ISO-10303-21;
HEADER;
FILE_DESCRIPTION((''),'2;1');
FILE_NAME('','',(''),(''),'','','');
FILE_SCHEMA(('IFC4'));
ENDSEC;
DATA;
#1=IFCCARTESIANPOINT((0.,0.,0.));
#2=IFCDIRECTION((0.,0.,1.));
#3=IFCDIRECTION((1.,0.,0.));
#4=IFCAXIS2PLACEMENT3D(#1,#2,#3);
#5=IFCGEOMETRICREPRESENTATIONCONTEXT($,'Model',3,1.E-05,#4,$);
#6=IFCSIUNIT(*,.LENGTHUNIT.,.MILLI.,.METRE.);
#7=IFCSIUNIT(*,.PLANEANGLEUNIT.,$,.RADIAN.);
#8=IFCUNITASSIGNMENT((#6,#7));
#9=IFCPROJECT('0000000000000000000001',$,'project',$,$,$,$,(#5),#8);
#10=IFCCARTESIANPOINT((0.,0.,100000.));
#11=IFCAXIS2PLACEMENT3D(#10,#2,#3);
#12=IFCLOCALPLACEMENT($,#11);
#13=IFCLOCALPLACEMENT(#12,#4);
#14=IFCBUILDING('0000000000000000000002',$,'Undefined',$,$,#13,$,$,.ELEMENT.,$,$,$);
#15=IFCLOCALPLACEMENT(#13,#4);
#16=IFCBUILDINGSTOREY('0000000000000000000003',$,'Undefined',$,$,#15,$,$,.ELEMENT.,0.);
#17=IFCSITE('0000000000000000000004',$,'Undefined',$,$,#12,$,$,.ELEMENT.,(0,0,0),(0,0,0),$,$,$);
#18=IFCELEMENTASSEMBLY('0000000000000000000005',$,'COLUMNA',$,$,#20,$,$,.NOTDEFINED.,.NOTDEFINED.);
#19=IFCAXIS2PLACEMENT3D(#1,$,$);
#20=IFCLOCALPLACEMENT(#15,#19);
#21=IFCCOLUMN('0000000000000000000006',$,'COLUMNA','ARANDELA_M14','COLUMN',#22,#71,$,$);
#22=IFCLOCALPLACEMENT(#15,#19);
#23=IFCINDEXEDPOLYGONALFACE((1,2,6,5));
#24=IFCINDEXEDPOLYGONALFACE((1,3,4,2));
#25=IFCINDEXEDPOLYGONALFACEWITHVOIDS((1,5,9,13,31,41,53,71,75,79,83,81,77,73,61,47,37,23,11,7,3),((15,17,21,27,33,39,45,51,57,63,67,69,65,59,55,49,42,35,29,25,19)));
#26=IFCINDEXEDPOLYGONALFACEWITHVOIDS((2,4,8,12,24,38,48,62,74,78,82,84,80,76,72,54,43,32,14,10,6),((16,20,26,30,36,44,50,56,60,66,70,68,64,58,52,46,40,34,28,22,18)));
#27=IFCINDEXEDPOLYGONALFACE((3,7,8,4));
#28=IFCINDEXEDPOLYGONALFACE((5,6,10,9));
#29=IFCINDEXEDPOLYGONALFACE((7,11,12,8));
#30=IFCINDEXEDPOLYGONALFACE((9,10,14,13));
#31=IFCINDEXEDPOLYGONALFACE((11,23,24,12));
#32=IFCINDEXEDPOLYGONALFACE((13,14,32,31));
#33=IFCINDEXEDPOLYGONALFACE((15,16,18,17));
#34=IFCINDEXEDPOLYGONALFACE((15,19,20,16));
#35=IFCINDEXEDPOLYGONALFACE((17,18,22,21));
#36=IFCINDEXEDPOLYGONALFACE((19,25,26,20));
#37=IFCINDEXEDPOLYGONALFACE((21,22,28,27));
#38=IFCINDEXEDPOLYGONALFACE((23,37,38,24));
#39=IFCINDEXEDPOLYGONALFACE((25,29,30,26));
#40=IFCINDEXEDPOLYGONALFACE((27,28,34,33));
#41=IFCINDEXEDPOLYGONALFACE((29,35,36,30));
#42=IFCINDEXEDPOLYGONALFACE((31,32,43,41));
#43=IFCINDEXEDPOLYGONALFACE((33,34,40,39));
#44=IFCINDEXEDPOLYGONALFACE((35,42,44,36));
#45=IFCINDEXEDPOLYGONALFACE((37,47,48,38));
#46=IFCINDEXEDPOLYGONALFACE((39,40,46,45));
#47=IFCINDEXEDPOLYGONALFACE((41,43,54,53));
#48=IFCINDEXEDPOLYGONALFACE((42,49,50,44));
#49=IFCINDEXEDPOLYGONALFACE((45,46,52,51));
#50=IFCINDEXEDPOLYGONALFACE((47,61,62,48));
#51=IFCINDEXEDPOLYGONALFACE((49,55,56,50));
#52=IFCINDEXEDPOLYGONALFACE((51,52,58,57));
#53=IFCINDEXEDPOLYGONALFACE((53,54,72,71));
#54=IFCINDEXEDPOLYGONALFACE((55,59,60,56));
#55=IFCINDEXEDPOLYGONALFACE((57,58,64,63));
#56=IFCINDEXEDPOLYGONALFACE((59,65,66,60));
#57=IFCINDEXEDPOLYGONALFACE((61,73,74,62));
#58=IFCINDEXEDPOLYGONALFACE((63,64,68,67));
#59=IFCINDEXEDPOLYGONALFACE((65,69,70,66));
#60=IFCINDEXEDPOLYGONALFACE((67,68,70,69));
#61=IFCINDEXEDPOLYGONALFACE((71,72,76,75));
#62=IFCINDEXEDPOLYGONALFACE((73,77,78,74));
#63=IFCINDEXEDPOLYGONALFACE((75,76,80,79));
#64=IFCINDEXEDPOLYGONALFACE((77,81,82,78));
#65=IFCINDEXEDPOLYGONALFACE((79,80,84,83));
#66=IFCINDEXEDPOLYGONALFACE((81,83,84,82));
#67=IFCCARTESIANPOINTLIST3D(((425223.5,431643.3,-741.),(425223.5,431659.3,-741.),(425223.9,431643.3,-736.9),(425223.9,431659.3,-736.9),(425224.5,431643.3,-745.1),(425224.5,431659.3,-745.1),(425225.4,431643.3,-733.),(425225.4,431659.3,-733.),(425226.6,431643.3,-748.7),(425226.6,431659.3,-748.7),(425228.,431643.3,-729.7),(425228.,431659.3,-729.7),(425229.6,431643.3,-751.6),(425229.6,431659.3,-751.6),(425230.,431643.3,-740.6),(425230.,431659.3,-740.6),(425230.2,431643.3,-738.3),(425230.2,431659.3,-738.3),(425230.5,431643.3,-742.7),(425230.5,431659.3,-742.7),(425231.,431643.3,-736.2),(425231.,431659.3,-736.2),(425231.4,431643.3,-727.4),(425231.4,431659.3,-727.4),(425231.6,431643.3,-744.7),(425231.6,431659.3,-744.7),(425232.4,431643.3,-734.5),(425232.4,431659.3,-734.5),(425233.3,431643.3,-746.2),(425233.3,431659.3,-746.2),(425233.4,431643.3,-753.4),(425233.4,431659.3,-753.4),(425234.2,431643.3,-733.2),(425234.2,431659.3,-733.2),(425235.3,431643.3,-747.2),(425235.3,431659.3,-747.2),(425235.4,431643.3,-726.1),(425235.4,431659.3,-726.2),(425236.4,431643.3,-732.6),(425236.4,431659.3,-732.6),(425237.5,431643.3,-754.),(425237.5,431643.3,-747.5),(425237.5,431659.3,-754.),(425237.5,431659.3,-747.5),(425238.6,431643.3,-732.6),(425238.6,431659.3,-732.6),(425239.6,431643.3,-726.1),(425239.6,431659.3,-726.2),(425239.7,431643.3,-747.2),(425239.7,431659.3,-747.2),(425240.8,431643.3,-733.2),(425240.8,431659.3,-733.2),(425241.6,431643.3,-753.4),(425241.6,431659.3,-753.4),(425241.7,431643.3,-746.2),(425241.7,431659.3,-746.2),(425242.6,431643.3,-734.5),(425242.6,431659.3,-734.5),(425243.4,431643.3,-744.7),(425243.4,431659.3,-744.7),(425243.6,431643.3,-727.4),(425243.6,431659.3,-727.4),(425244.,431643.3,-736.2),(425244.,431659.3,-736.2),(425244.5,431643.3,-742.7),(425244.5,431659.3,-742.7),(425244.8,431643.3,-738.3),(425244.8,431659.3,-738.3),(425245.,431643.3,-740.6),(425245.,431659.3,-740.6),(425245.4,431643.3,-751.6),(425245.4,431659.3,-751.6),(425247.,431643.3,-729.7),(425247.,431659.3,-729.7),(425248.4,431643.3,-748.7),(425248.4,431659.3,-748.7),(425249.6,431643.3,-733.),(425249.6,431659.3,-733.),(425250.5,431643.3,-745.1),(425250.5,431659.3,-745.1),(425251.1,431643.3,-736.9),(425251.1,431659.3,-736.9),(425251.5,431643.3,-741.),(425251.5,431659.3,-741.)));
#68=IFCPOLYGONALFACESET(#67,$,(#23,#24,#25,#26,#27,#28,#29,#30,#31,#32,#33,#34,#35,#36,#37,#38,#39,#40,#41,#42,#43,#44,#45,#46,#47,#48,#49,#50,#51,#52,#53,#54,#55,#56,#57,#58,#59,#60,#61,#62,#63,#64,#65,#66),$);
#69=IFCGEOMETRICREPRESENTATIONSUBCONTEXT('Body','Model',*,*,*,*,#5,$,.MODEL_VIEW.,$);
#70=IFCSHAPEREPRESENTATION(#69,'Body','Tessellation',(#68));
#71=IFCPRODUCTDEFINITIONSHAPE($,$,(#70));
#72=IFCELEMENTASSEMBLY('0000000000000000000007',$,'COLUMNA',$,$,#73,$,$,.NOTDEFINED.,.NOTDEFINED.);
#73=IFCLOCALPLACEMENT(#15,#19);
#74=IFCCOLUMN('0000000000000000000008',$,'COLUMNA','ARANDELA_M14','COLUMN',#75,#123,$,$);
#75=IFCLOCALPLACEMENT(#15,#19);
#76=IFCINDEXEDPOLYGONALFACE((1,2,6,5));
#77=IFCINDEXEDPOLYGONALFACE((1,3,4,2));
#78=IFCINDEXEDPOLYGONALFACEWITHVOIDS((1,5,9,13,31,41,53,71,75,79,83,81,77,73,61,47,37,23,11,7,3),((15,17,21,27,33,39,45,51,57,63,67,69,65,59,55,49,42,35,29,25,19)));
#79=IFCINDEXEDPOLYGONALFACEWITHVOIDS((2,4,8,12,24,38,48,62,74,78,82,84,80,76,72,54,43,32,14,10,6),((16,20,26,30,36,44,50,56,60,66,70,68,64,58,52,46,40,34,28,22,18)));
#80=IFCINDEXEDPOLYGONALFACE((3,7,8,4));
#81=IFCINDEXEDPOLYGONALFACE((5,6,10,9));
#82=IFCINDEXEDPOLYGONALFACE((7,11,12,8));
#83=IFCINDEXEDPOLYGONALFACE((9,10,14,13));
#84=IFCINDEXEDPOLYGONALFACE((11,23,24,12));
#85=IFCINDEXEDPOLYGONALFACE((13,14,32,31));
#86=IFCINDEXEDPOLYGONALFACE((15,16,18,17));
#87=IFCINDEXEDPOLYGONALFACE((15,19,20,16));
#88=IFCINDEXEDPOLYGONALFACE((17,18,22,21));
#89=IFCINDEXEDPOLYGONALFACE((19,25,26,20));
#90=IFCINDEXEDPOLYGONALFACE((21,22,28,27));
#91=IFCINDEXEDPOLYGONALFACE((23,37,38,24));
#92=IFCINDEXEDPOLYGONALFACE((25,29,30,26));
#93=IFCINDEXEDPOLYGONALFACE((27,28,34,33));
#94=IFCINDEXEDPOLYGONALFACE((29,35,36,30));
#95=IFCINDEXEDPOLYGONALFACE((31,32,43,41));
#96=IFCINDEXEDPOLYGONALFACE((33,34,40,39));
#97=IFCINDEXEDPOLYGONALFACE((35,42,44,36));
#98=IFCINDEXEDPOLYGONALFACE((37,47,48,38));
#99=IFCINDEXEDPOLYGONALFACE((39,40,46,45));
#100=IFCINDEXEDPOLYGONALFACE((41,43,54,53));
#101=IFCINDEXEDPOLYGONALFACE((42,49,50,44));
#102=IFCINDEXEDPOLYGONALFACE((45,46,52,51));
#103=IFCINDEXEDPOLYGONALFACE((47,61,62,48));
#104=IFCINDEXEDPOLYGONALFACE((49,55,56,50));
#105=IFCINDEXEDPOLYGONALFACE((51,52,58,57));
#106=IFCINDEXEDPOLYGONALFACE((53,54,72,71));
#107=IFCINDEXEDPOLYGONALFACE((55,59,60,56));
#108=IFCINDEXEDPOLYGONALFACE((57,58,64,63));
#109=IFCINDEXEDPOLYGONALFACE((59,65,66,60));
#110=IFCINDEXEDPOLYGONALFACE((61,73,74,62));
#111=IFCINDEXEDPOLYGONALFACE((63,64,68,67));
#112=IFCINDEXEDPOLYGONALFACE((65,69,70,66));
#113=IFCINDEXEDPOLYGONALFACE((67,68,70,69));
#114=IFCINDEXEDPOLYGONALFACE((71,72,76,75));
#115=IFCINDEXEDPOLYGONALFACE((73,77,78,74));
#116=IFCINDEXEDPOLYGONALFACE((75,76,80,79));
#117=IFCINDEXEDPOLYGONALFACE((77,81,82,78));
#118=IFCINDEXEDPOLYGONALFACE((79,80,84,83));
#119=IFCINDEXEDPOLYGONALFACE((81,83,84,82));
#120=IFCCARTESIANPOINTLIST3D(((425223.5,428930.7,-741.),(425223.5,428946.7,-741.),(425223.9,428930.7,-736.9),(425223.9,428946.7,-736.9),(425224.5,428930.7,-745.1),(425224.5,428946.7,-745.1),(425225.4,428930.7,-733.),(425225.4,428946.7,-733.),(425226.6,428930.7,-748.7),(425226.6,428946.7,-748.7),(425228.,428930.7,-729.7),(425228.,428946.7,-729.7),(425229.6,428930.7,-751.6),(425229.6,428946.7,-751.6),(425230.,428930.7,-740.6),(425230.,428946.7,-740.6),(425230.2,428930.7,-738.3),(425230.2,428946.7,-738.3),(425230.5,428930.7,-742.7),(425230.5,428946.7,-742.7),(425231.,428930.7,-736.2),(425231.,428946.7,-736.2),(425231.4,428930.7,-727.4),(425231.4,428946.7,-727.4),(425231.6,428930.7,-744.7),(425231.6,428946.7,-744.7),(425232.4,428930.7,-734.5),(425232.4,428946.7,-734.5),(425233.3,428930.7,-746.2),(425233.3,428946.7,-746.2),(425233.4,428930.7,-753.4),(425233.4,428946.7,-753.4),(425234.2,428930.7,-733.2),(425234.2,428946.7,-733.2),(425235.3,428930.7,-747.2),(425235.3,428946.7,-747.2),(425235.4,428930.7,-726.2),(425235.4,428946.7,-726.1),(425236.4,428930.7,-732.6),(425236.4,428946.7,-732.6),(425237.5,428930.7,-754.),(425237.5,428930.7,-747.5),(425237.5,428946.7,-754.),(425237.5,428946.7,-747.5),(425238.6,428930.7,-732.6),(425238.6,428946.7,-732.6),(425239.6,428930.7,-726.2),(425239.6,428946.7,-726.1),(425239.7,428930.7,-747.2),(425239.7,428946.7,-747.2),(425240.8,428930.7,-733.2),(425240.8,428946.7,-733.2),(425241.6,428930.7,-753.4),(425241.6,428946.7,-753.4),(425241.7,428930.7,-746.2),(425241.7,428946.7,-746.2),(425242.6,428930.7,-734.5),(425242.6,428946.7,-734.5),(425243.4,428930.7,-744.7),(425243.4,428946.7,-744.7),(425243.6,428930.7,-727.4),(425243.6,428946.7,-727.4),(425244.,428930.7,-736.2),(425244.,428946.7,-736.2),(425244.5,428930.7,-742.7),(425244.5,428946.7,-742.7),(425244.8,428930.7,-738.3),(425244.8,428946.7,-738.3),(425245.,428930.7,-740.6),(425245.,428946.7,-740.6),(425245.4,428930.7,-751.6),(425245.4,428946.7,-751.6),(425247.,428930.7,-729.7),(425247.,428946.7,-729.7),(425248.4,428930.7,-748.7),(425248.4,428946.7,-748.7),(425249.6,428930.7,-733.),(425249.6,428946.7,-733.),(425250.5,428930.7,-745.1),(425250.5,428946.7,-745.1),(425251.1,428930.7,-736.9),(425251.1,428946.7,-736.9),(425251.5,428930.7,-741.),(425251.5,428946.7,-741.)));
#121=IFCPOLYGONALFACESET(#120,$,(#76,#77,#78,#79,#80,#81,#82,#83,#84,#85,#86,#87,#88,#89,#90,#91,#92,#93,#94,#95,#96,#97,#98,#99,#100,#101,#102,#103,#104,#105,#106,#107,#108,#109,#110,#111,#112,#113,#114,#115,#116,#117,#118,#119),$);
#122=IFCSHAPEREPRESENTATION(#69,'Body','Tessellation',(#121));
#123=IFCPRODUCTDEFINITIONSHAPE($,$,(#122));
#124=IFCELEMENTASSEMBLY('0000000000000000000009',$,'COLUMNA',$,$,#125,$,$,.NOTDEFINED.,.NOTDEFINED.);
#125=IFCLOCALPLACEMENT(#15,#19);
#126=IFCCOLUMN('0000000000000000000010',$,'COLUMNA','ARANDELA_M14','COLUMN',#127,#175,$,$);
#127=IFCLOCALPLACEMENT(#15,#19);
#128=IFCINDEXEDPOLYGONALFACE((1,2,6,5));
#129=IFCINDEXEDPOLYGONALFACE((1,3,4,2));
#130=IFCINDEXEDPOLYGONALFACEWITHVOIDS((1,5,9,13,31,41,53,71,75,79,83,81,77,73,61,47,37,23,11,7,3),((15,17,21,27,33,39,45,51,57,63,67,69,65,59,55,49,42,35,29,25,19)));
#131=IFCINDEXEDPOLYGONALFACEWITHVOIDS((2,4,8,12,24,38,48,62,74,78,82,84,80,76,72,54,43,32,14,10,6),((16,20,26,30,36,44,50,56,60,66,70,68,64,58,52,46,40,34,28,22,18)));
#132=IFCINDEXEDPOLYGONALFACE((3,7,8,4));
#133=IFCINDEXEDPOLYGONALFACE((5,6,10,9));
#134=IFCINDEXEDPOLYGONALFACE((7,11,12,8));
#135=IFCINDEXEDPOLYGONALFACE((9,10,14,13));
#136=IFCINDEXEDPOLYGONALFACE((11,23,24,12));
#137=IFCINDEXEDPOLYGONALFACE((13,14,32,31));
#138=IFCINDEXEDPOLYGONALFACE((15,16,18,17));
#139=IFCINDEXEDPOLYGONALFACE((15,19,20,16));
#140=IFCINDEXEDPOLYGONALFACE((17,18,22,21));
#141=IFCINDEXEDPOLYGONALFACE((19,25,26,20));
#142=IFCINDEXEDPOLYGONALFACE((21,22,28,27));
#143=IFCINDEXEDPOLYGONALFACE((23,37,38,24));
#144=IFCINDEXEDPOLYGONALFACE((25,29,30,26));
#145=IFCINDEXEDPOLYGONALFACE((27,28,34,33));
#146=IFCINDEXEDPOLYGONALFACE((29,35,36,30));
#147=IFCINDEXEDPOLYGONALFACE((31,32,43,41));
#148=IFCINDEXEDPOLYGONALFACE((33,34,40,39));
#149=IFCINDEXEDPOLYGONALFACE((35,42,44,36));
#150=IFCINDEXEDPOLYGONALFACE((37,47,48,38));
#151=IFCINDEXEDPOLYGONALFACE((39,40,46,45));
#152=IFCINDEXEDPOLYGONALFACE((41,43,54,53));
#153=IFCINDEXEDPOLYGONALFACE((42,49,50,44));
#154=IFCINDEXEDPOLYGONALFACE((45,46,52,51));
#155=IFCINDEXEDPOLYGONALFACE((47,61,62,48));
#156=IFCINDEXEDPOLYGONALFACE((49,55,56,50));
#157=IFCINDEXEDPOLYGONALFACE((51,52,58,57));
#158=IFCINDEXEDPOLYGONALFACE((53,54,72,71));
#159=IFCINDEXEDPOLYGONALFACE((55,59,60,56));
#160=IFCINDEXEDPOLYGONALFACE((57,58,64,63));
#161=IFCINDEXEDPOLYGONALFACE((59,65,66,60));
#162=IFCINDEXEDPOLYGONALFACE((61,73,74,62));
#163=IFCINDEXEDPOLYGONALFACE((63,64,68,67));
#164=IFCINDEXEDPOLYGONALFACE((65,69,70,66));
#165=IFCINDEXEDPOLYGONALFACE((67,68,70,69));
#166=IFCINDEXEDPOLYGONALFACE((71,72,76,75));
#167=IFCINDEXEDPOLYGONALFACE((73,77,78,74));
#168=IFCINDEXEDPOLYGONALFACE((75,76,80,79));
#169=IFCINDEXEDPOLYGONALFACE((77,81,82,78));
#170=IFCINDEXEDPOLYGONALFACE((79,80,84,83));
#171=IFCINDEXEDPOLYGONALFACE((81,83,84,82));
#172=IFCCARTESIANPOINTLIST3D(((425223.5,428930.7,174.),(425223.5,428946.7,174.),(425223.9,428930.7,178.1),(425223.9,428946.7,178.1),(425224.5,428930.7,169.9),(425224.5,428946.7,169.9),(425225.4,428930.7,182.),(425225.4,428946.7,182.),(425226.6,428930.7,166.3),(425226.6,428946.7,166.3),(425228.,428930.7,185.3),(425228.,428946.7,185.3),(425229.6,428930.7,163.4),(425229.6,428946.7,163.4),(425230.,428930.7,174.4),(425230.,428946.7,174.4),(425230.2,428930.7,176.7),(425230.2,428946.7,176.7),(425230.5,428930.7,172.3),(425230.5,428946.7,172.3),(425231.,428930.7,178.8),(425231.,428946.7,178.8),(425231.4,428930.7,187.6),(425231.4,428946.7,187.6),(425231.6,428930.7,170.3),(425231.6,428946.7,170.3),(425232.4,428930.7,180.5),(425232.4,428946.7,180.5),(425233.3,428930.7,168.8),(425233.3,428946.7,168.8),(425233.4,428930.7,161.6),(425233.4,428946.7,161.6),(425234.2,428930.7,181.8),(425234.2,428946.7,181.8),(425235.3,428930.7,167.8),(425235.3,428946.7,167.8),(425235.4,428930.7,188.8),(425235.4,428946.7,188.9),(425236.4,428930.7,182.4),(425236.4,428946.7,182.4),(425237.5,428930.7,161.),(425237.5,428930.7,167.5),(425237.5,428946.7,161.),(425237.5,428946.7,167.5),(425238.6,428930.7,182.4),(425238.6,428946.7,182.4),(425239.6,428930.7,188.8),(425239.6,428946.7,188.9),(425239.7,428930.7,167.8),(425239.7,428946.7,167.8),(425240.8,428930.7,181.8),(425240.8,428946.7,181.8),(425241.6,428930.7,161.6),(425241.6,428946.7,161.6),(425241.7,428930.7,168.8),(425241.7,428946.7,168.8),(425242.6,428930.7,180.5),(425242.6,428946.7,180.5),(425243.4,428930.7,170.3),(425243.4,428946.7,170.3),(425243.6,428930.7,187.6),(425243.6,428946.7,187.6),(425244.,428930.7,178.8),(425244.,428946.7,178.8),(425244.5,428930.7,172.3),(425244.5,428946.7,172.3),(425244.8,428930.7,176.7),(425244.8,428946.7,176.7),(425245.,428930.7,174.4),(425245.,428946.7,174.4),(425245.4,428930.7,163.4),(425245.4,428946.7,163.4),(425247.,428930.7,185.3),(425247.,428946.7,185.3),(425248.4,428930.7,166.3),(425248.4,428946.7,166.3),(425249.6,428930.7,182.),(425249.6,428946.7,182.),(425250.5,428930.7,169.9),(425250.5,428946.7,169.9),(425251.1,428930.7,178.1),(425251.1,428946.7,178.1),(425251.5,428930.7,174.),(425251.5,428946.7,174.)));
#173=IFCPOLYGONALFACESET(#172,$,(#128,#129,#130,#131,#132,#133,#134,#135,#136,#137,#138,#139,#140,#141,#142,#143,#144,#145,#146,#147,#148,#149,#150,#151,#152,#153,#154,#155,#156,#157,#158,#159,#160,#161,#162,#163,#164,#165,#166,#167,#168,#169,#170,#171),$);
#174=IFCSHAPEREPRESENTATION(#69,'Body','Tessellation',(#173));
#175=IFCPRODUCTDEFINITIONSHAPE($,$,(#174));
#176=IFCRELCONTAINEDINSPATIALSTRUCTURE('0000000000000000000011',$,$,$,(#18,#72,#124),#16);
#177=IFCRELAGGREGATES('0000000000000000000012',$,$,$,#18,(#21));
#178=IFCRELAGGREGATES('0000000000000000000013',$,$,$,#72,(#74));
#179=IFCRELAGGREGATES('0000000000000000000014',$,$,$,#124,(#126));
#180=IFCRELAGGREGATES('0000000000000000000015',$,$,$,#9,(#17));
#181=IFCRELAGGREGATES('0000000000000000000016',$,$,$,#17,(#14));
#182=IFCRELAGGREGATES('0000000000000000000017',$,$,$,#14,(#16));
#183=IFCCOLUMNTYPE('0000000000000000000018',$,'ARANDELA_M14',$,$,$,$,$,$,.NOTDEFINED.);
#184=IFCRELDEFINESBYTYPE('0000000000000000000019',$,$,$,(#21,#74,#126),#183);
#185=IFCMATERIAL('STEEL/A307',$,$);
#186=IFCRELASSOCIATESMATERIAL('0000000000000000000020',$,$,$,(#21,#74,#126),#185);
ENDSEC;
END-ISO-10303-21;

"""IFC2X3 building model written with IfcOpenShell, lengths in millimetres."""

from ifc_helpers import new_model, si_unit, frame, origin_with_axes, origin_2d_with_axis, place, context, subcontext, project, spatial, hollow_circle, extrude, material, type_object, element, aggregate, save


model = new_model("IFC2X3")

# Units and contexts
model_context = context("Model", 3, precision=1e-05, world=origin_with_axes())
body_context = subcontext(model_context, "Body", "Model", "MODEL_VIEW")
ifc_project = project(units=[si_unit("LENGTHUNIT", "METRE", prefix="MILLI"), si_unit("PLANEANGLEUNIT", "RADIAN")], contexts=[model_context])

# Site, building, storey
site_placement = place(None, frame((0.0, 0.0, 100000.0), z_axis=(0.0, 0.0, 1.0), x_axis=(1.0, 0.0, 0.0)))
site = spatial("IfcSite", under=ifc_project, at=site_placement, Name="Undefined", CompositionType="ELEMENT", RefLatitude=(0, 0, 0), RefLongitude=(0, 0, 0))
building_placement = place(site_placement, origin_with_axes())
building = spatial("IfcBuilding", under=site, at=building_placement, Name="Undefined", CompositionType="ELEMENT")
storey_placement = place(building_placement, origin_with_axes())
storey = spatial("IfcBuildingStorey", under=building, at=storey_placement, Name="Undefined", CompositionType="ELEMENT", Elevation=0.0)

# Element assemblies, columns
assembly_1_placement = place(storey_placement, origin_with_axes())
assembly_1 = element("IfcElementAssembly", 1, at=assembly_1_placement, inside=storey, Name="COLUMNA", AssemblyPlace="NOTDEFINED", PredefinedType="NOTDEFINED")
ifc_material_1 = material(Name="STEEL/A307")
column_type = type_object("IfcColumnType", Name="ARANDELA_M14", PredefinedType="NOTDEFINED")
column_1_placement = place(assembly_1_placement, frame((425237.5, 431659.3, -740.0), z_axis=(0.0, -1.0, 0.000285), x_axis=(-1.0, 0.0, 0.0)))
column_1 = element("IfcColumn", 2, at=column_1_placement, type_object=column_type, material=ifc_material_1, Name="COLUMNA", Description="ARANDELA_M14", ObjectType="COLUMN", context=body_context, shape_type="SweptSolid", body=[
    extrude(hollow_circle(Radius=14.0, WallThickness=6.5, at=origin_2d_with_axis()), frame((0.0, 0.0, 16.0), z_axis=(0.0, 0.0, -1.0), x_axis=(0.0, 1.0, 0.0)), (0.0, 0.0, 1.0), 16.0),
])
aggregate(assembly_1, [column_1])
assembly_2_placement = place(storey_placement, origin_with_axes())
assembly_2 = element("IfcElementAssembly", 3, at=assembly_2_placement, inside=storey, Name="COLUMNA", AssemblyPlace="NOTDEFINED", PredefinedType="NOTDEFINED")
column_2_placement = place(assembly_2_placement, frame((425237.5, 428930.7, -740.0), z_axis=(0.0, 1.0, 0.000285), x_axis=(1.0, 0.0, 0.0)))
column_2 = element("IfcColumn", 4, at=column_2_placement, type_object=column_type, material=ifc_material_1, Name="COLUMNA", Description="ARANDELA_M14", ObjectType="COLUMN", context=body_context, shape_type="SweptSolid", body=[
    extrude(hollow_circle(Radius=14.0, WallThickness=6.5, at=origin_2d_with_axis()), frame((0.0, 0.0, 16.0), z_axis=(0.0, 0.0, -1.0), x_axis=(0.0, 1.0, 0.0)), (0.0, 0.0, 1.0), 16.0),
])
aggregate(assembly_2, [column_2])
assembly_3_placement = place(storey_placement, origin_with_axes())
assembly_3 = element("IfcElementAssembly", 5, at=assembly_3_placement, inside=storey, Name="COLUMNA", AssemblyPlace="NOTDEFINED", PredefinedType="NOTDEFINED")
column_3_placement = place(assembly_3_placement, frame((425237.5, 428930.7, 175.0), z_axis=(0.0, 1.0, 0.000285), x_axis=(1.0, 0.0, 0.0)))
column_3 = element("IfcColumn", 6, at=column_3_placement, type_object=column_type, material=ifc_material_1, Name="COLUMNA", Description="ARANDELA_M14", ObjectType="COLUMN", context=body_context, shape_type="SweptSolid", body=[
    extrude(hollow_circle(Radius=14.0, WallThickness=6.5, at=origin_2d_with_axis()), frame((0.0, 0.0, 16.0), z_axis=(0.0, 0.0, -1.0), x_axis=(0.0, 1.0, 0.0)), (0.0, 0.0, 1.0), 16.0),
])
aggregate(assembly_3, [column_3])

save(model, "model.ifc")
